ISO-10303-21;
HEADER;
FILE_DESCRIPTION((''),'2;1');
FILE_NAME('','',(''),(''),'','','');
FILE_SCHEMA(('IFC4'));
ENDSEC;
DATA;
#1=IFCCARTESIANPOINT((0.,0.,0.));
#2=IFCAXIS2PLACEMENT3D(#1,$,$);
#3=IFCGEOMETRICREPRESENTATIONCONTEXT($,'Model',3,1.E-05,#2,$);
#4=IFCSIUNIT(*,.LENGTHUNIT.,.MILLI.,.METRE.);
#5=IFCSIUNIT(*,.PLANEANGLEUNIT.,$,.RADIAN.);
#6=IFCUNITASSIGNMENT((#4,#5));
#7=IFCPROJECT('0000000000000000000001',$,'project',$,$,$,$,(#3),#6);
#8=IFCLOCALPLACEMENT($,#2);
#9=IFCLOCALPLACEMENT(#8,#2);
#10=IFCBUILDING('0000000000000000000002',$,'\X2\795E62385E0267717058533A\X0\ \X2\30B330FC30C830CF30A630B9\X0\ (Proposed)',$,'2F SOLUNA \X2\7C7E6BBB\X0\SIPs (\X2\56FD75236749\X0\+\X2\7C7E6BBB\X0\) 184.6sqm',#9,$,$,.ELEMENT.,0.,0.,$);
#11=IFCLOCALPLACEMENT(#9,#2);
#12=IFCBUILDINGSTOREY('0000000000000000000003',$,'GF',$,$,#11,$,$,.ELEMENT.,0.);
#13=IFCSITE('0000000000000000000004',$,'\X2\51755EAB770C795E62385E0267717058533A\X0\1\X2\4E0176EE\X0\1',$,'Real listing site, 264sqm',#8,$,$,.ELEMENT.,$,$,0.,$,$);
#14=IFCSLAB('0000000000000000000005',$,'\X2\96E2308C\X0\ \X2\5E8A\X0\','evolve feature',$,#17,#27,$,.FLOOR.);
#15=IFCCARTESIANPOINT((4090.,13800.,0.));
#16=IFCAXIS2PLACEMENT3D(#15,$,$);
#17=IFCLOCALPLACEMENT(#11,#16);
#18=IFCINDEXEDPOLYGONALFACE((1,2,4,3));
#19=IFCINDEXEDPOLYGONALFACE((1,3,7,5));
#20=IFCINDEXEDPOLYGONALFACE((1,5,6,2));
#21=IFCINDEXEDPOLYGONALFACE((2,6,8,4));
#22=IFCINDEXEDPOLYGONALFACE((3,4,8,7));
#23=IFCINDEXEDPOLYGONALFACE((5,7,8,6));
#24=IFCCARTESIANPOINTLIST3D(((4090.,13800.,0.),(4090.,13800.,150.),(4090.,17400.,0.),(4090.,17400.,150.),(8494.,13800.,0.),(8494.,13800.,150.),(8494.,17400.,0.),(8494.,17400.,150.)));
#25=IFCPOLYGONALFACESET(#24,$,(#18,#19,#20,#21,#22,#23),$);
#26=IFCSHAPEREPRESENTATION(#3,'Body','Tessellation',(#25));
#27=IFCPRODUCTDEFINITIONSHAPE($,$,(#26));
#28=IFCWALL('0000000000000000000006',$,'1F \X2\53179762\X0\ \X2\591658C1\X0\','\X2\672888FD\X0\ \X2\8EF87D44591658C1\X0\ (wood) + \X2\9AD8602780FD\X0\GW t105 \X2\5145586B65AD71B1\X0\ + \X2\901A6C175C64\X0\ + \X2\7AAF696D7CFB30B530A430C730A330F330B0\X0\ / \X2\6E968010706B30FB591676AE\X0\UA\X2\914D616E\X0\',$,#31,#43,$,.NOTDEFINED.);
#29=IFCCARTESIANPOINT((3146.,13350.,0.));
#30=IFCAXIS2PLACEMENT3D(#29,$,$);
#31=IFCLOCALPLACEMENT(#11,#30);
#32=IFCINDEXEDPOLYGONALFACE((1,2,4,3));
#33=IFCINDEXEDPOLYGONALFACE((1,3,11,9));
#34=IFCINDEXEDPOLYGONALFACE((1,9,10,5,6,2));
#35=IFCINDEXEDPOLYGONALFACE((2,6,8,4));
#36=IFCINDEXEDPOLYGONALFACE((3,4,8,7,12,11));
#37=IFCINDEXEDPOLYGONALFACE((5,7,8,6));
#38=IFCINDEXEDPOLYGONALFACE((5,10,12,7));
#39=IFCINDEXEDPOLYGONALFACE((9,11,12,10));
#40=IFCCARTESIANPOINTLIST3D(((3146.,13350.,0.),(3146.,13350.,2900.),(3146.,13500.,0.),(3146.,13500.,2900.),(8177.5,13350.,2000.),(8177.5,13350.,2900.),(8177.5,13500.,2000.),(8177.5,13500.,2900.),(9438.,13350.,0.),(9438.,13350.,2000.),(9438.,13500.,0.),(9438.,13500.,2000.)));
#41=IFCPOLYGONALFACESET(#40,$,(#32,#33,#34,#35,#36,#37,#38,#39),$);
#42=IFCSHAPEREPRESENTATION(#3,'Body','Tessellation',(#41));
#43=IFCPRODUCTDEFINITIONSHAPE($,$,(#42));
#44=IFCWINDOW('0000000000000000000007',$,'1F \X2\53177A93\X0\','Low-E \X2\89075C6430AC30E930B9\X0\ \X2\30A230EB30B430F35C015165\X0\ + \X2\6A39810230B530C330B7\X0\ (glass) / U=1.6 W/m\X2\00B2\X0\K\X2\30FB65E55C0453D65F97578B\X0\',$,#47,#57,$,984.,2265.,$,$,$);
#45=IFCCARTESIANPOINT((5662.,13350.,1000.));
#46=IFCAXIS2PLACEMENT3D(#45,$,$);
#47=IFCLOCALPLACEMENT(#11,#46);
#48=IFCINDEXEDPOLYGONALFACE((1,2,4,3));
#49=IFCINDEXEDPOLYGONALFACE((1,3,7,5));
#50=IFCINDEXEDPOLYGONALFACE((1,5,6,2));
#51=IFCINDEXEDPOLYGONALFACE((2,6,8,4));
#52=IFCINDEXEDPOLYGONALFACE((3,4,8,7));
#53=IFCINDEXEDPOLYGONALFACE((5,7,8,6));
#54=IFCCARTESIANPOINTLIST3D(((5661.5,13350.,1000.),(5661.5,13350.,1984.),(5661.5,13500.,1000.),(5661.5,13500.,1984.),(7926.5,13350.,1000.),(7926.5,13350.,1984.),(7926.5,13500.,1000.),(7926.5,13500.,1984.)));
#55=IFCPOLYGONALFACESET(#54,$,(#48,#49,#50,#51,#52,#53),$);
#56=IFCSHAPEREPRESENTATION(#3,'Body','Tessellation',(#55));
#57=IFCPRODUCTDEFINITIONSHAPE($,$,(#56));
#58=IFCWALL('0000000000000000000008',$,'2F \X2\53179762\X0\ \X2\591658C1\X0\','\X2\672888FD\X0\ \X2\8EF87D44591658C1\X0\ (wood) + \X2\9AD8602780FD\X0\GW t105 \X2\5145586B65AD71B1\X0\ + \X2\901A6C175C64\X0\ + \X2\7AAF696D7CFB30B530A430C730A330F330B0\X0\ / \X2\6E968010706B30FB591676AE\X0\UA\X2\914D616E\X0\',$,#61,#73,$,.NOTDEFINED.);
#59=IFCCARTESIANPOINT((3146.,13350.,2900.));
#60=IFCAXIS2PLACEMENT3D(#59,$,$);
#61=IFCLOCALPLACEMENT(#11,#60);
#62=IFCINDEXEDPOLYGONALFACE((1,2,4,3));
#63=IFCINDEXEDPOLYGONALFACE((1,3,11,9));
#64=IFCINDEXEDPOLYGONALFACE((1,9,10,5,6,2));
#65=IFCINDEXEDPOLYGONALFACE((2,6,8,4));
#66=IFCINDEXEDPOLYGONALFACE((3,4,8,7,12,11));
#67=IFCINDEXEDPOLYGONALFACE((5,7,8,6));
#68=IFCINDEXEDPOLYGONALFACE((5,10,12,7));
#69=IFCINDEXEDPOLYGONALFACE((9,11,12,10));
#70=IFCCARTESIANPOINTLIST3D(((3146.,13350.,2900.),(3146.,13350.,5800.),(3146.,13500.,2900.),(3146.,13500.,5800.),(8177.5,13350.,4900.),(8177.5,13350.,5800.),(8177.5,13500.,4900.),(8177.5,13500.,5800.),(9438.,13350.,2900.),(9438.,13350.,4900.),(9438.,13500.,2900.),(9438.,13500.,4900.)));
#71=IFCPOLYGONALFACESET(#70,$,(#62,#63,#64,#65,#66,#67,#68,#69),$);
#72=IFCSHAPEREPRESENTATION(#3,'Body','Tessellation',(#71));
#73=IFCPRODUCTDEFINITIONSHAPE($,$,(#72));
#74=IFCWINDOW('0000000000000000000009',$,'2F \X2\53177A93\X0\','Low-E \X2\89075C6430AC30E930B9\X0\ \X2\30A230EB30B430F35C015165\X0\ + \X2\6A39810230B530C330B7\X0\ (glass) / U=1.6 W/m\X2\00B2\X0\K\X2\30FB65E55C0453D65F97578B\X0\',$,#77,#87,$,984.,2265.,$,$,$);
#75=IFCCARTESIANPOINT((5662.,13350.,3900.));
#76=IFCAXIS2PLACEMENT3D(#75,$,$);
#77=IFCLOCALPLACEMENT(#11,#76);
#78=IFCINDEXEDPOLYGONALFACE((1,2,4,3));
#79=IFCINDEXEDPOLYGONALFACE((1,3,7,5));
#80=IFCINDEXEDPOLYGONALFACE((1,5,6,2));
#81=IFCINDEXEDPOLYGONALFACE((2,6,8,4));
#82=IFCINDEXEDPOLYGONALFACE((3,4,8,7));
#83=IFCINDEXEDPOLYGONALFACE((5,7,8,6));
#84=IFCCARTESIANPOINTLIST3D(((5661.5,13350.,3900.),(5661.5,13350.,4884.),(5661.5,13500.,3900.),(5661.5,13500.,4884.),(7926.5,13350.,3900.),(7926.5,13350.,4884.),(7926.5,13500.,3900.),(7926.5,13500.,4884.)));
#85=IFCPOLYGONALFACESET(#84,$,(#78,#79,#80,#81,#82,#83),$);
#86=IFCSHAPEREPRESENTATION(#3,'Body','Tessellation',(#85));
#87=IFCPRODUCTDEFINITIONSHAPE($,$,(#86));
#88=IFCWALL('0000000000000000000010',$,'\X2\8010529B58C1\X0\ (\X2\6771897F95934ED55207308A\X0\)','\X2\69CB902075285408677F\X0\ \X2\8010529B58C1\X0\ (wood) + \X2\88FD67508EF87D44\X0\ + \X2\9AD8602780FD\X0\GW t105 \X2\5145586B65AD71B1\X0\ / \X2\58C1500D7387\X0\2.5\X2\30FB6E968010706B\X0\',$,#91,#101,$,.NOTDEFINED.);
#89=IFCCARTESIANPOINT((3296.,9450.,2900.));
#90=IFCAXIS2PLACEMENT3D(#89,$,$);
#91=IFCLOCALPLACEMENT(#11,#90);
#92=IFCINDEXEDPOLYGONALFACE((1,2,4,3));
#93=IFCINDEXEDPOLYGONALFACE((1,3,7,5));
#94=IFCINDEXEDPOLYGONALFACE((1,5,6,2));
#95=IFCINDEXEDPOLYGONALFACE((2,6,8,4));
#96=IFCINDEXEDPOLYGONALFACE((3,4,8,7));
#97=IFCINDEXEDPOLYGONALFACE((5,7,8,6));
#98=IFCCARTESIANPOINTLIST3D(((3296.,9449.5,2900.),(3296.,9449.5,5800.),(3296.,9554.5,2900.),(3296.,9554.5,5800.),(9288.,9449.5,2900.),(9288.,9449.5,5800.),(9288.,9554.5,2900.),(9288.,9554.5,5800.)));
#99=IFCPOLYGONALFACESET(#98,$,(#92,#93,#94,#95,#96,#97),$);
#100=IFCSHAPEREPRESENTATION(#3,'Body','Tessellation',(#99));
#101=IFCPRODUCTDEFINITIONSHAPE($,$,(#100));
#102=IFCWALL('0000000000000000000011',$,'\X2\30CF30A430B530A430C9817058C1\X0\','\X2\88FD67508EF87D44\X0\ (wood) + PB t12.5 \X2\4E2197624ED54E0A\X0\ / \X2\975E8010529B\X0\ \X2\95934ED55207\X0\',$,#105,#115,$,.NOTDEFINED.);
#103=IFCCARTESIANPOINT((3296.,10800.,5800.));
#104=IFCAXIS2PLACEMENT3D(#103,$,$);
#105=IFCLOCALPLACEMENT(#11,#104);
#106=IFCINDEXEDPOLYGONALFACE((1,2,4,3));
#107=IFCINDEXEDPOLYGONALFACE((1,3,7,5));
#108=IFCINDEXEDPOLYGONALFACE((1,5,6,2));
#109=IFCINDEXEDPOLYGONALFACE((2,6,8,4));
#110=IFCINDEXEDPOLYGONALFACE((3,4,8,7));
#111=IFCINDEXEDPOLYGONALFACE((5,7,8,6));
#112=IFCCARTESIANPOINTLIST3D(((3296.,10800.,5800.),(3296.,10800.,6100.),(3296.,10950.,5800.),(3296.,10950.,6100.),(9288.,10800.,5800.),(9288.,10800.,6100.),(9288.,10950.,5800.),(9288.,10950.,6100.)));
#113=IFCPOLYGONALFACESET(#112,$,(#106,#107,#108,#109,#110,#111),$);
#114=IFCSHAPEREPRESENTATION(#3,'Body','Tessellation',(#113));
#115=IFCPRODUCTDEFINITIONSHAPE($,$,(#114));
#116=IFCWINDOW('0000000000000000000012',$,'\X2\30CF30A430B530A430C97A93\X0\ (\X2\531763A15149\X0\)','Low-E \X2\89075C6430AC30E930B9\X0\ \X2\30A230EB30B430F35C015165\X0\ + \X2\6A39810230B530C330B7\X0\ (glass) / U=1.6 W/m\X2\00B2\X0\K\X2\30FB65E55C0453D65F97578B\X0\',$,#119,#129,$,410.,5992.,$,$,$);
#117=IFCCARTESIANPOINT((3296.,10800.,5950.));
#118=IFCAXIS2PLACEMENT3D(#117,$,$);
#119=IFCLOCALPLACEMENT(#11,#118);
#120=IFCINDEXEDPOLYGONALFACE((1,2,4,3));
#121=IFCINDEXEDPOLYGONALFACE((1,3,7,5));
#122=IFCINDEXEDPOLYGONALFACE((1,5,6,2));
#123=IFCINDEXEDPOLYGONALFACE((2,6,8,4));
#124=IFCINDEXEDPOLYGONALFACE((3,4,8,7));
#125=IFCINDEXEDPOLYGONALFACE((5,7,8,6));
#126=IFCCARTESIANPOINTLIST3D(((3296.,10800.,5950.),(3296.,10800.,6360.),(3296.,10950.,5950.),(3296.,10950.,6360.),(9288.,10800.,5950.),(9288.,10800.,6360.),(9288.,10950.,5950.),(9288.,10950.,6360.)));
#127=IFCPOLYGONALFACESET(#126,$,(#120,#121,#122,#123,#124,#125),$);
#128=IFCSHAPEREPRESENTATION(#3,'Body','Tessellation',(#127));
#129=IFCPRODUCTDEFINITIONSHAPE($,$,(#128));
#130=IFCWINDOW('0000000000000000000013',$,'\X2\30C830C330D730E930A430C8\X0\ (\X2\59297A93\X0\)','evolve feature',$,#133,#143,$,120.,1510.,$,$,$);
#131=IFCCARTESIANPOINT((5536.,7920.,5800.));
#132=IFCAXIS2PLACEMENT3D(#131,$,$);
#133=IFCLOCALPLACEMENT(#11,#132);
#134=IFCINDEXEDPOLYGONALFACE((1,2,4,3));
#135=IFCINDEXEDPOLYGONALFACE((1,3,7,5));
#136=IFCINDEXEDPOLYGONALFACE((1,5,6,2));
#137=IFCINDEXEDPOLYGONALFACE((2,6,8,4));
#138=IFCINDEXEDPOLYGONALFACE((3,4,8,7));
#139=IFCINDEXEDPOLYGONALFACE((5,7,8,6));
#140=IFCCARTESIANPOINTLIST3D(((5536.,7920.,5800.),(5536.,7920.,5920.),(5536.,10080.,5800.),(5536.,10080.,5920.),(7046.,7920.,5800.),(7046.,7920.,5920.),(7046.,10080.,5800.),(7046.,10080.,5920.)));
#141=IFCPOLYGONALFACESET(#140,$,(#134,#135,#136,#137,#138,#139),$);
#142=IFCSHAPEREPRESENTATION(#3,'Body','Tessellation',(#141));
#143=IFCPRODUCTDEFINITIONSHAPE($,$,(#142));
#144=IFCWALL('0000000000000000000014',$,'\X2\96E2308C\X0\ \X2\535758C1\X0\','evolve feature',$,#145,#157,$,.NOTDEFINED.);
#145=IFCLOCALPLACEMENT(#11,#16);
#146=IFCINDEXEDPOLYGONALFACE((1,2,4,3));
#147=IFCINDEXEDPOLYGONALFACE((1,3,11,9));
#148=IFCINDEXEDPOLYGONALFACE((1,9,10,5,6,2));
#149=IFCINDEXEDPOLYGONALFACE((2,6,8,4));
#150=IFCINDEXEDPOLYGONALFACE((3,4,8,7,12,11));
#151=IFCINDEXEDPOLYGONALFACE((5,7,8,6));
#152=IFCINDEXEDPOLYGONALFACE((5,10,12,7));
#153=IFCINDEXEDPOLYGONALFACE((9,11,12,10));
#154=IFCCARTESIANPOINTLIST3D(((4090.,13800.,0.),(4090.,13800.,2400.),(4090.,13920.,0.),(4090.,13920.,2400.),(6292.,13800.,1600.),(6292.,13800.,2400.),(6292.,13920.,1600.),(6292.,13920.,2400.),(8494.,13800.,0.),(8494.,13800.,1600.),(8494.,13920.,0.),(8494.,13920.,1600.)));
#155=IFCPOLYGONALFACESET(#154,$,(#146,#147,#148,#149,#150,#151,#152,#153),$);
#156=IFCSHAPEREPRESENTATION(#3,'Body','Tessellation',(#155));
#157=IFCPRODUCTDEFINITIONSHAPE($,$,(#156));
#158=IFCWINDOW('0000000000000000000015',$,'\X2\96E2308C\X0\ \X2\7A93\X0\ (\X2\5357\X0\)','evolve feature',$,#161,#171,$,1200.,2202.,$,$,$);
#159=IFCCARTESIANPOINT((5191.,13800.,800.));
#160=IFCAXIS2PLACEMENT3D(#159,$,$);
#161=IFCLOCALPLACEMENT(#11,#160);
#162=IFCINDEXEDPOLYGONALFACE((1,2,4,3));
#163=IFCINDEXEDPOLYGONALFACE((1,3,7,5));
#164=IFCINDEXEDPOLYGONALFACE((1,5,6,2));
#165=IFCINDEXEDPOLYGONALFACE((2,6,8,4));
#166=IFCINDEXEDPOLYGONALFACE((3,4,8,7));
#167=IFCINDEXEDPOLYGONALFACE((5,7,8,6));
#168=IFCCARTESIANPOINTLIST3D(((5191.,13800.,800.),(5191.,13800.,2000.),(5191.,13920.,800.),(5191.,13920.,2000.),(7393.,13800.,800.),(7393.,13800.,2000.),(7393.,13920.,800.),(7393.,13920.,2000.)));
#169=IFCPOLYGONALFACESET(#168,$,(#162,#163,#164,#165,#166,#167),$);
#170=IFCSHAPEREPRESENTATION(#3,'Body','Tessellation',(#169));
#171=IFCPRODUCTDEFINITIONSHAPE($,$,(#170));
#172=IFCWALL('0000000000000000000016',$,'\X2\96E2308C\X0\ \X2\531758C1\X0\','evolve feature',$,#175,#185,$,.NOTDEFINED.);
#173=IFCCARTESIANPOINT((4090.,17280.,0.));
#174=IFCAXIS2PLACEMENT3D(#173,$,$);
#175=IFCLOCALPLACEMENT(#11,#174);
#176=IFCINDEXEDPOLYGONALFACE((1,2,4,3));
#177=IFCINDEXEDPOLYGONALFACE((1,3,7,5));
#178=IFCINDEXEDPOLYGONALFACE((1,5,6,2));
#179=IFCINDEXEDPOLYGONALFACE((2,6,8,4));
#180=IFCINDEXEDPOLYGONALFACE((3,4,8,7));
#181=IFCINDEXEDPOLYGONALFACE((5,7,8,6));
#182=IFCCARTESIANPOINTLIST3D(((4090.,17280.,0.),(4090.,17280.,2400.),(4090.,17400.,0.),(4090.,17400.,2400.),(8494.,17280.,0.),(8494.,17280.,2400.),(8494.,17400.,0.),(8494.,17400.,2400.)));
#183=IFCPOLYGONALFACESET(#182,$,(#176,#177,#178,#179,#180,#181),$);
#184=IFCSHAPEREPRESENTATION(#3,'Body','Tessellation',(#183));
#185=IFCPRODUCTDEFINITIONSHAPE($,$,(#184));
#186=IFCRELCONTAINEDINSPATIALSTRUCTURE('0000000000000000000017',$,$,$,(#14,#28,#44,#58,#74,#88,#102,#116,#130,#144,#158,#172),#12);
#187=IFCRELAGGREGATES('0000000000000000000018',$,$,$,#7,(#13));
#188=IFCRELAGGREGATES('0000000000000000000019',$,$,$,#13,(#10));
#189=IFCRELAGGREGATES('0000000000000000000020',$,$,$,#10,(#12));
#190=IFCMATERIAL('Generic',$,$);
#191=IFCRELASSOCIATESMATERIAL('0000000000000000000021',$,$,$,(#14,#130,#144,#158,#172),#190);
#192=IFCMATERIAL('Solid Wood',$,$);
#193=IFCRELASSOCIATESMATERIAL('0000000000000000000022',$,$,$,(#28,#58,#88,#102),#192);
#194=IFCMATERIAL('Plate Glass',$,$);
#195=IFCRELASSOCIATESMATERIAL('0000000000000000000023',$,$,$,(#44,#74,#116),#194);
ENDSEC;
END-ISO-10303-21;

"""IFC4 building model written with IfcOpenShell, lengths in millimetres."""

from ifc_helpers import new_model, si_unit, frame, frame_2d, origin, place, context, project, spatial, rectangle, extrude, material, element, fill, save


model = new_model("IFC4")

# Units and contexts
model_context = context("Model", 3, precision=1e-05, world=origin())
ifc_project = project(units=[si_unit("LENGTHUNIT", "METRE", prefix="MILLI"), si_unit("PLANEANGLEUNIT", "RADIAN")], contexts=[model_context])

# Site, building, storey
site_placement = place(None, origin())
site = spatial("IfcSite", under=ifc_project, at=site_placement, Name="兵庫県神戸市東灘区1丁目1", ObjectType="Real listing site, 264sqm", CompositionType="ELEMENT", RefElevation=0.0)
building_placement = place(site_placement, origin())
building = spatial("IfcBuilding", under=site, at=building_placement, Name="神戸市東灘区 コートハウス (Proposed)", ObjectType="2F SOLUNA 籾殻SIPs (国産杉+籾殻) 184.6sqm", CompositionType="ELEMENT", ElevationOfRefHeight=0.0, ElevationOfTerrain=0.0)
storey_placement = place(building_placement, origin())
storey = spatial("IfcBuildingStorey", under=building, at=storey_placement, Name="GF", CompositionType="ELEMENT", Elevation=0.0)

# Slab
ifc_material_1 = material(Name="Generic")
slab_placement = place(storey_placement, frame((4090.0, 13800.0, 0.0)))
element("IfcSlab", 1, at=slab_placement, inside=storey, material=ifc_material_1, Name="離れ 床", Description="evolve feature", PredefinedType="FLOOR", context=model_context, shape_type="SweptSolid", body=[
    extrude(rectangle(XDim=4404.0, YDim=3600.0, at=frame_2d((2202.0, 1800.0))), frame((4090.0, 13800.0, 0.0)), (0.0, 0.0, 1.0), 150.0),
])

# Wall, opening, window
ifc_material_2 = material(Name="Solid Wood")
wall_1_placement = place(storey_placement, frame((3146.0, 13350.0, 0.0)))
wall_1 = element("IfcWall", 2, at=wall_1_placement, inside=storey, material=ifc_material_2, Name="1F 北面 外壁", Description="木製 軸組外壁 (wood) + 高性能GW t105 充填断熱 + 通気層 + 窯業系サイディング / 準耐火・外皮UA配慮", PredefinedType="NOTDEFINED", context=model_context, shape_type="SweptSolid", body=[
    extrude(rectangle(XDim=6292.0, YDim=150.0, at=frame_2d((3146.0, 75.0))), frame((3146.0, 13350.0, 0.0)), (0.0, 0.0, 1.0), 2900.0),
])
opening_1_placement = place(storey_placement, frame((5662.0, 13350.0, 1000.0)))
opening_1 = element("IfcOpeningElement", 3, at=opening_1_placement, cuts=wall_1, PredefinedType="NOTDEFINED", context=model_context, shape_type="SweptSolid", body=[
    extrude(rectangle(XDim=2265.0, YDim=150.0, at=frame_2d((1132.0, 75.0))), frame((5662.0, 13350.0, 1000.0)), (0.0, 0.0, 1.0), 984.0),
])
ifc_material_3 = material(Name="Plate Glass")
window_1_placement = place(storey_placement, frame((5662.0, 13350.0, 1000.0)))
window_1 = element("IfcWindow", 4, at=window_1_placement, inside=storey, material=ifc_material_3, Name="1F 北窓", Description="Low-E 複層ガラス アルゴン封入 + 樹脂サッシ (glass) / U=1.6 W/m²K・日射取得型", OverallHeight=984.0, OverallWidth=2265.0, context=model_context, shape_type="SweptSolid", body=[
    extrude(rectangle(XDim=2265.0, YDim=150.0, at=frame_2d((1132.0, 75.0))), frame((5662.0, 13350.0, 1000.0)), (0.0, 0.0, 1.0), 984.0),
])
fill(opening_1, window_1)

# Wall, opening, window
wall_2_placement = place(storey_placement, frame((3146.0, 13350.0, 2900.0)))
wall_2 = element("IfcWall", 5, at=wall_2_placement, inside=storey, material=ifc_material_2, Name="2F 北面 外壁", Description="木製 軸組外壁 (wood) + 高性能GW t105 充填断熱 + 通気層 + 窯業系サイディング / 準耐火・外皮UA配慮", PredefinedType="NOTDEFINED", context=model_context, shape_type="SweptSolid", body=[
    extrude(rectangle(XDim=6292.0, YDim=150.0, at=frame_2d((3146.0, 75.0))), frame((3146.0, 13350.0, 2900.0)), (0.0, 0.0, 1.0), 2900.0),
])
opening_2_placement = place(storey_placement, frame((5662.0, 13350.0, 3900.0)))
opening_2 = element("IfcOpeningElement", 6, at=opening_2_placement, cuts=wall_2, PredefinedType="NOTDEFINED", context=model_context, shape_type="SweptSolid", body=[
    extrude(rectangle(XDim=2265.0, YDim=150.0, at=frame_2d((1132.0, 75.0))), frame((5662.0, 13350.0, 3900.0)), (0.0, 0.0, 1.0), 984.0),
])
window_2_placement = place(storey_placement, frame((5662.0, 13350.0, 3900.0)))
window_2 = element("IfcWindow", 7, at=window_2_placement, inside=storey, material=ifc_material_3, Name="2F 北窓", Description="Low-E 複層ガラス アルゴン封入 + 樹脂サッシ (glass) / U=1.6 W/m²K・日射取得型", OverallHeight=984.0, OverallWidth=2265.0, context=model_context, shape_type="SweptSolid", body=[
    extrude(rectangle(XDim=2265.0, YDim=150.0, at=frame_2d((1132.0, 75.0))), frame((5662.0, 13350.0, 3900.0)), (0.0, 0.0, 1.0), 984.0),
])
fill(opening_2, window_2)

# Wall
wall_3_placement = place(storey_placement, frame((3296.0, 9450.0, 2900.0)))
element("IfcWall", 8, at=wall_3_placement, inside=storey, material=ifc_material_2, Name="耐力壁 (東西間仕切り)", Description="構造用合板 耐力壁 (wood) + 製材軸組 + 高性能GW t105 充填断熱 / 壁倍率2.5・準耐火", PredefinedType="NOTDEFINED", context=model_context, shape_type="SweptSolid", body=[
    extrude(rectangle(XDim=5992.0, YDim=105.0, at=frame_2d((2996.0, 52.0))), frame((3296.0, 9450.0, 2900.0)), (0.0, 0.0, 1.0), 2900.0),
])

# Wall, opening, window
wall_4_placement = place(storey_placement, frame((3296.0, 10800.0, 5800.0)))
wall_4 = element("IfcWall", 9, at=wall_4_placement, inside=storey, material=ifc_material_2, Name="ハイサイド腰壁", Description="製材軸組 (wood) + PB t12.5 両面仕上 / 非耐力 間仕切", PredefinedType="NOTDEFINED", context=model_context, shape_type="SweptSolid", body=[
    extrude(rectangle(XDim=5992.0, YDim=150.0, at=frame_2d((2996.0, 75.0))), frame((3296.0, 10800.0, 5800.0)), (0.0, 0.0, 1.0), 700.0),
])
opening_3_placement = place(storey_placement, frame((3296.0, 10800.0, 5950.0)))
opening_3 = element("IfcOpeningElement", 10, at=opening_3_placement, cuts=wall_4, PredefinedType="NOTDEFINED", context=model_context, shape_type="SweptSolid", body=[
    extrude(rectangle(XDim=5992.0, YDim=150.0, at=frame_2d((2996.0, 75.0))), frame((3296.0, 10800.0, 5950.0)), (0.0, 0.0, 1.0), 410.0),
])
window_3_placement = place(storey_placement, frame((3296.0, 10800.0, 5950.0)))
window_3 = element("IfcWindow", 11, at=window_3_placement, inside=storey, material=ifc_material_3, Name="ハイサイド窓 (北採光)", Description="Low-E 複層ガラス アルゴン封入 + 樹脂サッシ (glass) / U=1.6 W/m²K・日射取得型", OverallHeight=410.0, OverallWidth=5992.0, context=model_context, shape_type="SweptSolid", body=[
    extrude(rectangle(XDim=5992.0, YDim=150.0, at=frame_2d((2996.0, 75.0))), frame((3296.0, 10800.0, 5950.0)), (0.0, 0.0, 1.0), 410.0),
])
fill(opening_3, window_3)

# Window
window_4_placement = place(storey_placement, frame((5536.0, 7920.0, 5800.0)))
element("IfcWindow", 12, at=window_4_placement, inside=storey, material=ifc_material_1, Name="トップライト (天窓)", Description="evolve feature", OverallHeight=120.0, OverallWidth=1510.0, context=model_context, shape_type="SweptSolid", body=[
    extrude(rectangle(XDim=1510.0, YDim=2160.0, at=frame_2d((755.0, 1080.0))), frame((5536.0, 7920.0, 5800.0)), (0.0, 0.0, 1.0), 120.0),
])

# Wall, opening, window
wall_5_placement = place(storey_placement, frame((4090.0, 13800.0, 0.0)))
wall_5 = element("IfcWall", 13, at=wall_5_placement, inside=storey, material=ifc_material_1, Name="離れ 南壁", Description="evolve feature", PredefinedType="NOTDEFINED", context=model_context, shape_type="SweptSolid", body=[
    extrude(rectangle(XDim=4404.0, YDim=120.0, at=frame_2d((2202.0, 60.0))), frame((4090.0, 13800.0, 0.0)), (0.0, 0.0, 1.0), 2400.0),
])
opening_4_placement = place(storey_placement, frame((5191.0, 13800.0, 800.0)))
opening_4 = element("IfcOpeningElement", 14, at=opening_4_placement, cuts=wall_5, PredefinedType="NOTDEFINED", context=model_context, shape_type="SweptSolid", body=[
    extrude(rectangle(XDim=2202.0, YDim=120.0, at=frame_2d((1101.0, 60.0))), frame((5191.0, 13800.0, 800.0)), (0.0, 0.0, 1.0), 1200.0),
])
window_5_placement = place(storey_placement, frame((5191.0, 13800.0, 800.0)))
window_5 = element("IfcWindow", 15, at=window_5_placement, inside=storey, material=ifc_material_1, Name="離れ 窓 (南)", Description="evolve feature", OverallHeight=1200.0, OverallWidth=2202.0, context=model_context, shape_type="SweptSolid", body=[
    extrude(rectangle(XDim=2202.0, YDim=120.0, at=frame_2d((1101.0, 60.0))), frame((5191.0, 13800.0, 800.0)), (0.0, 0.0, 1.0), 1200.0),
])
fill(opening_4, window_5)

# Wall
wall_6_placement = place(storey_placement, frame((4090.0, 17280.0, 0.0)))
element("IfcWall", 16, at=wall_6_placement, inside=storey, material=ifc_material_1, Name="離れ 北壁", Description="evolve feature", PredefinedType="NOTDEFINED", context=model_context, shape_type="SweptSolid", body=[
    extrude(rectangle(XDim=4404.0, YDim=120.0, at=frame_2d((2202.0, 60.0))), frame((4090.0, 17280.0, 0.0)), (0.0, 0.0, 1.0), 2400.0),
])

save(model, "model.ifc")
